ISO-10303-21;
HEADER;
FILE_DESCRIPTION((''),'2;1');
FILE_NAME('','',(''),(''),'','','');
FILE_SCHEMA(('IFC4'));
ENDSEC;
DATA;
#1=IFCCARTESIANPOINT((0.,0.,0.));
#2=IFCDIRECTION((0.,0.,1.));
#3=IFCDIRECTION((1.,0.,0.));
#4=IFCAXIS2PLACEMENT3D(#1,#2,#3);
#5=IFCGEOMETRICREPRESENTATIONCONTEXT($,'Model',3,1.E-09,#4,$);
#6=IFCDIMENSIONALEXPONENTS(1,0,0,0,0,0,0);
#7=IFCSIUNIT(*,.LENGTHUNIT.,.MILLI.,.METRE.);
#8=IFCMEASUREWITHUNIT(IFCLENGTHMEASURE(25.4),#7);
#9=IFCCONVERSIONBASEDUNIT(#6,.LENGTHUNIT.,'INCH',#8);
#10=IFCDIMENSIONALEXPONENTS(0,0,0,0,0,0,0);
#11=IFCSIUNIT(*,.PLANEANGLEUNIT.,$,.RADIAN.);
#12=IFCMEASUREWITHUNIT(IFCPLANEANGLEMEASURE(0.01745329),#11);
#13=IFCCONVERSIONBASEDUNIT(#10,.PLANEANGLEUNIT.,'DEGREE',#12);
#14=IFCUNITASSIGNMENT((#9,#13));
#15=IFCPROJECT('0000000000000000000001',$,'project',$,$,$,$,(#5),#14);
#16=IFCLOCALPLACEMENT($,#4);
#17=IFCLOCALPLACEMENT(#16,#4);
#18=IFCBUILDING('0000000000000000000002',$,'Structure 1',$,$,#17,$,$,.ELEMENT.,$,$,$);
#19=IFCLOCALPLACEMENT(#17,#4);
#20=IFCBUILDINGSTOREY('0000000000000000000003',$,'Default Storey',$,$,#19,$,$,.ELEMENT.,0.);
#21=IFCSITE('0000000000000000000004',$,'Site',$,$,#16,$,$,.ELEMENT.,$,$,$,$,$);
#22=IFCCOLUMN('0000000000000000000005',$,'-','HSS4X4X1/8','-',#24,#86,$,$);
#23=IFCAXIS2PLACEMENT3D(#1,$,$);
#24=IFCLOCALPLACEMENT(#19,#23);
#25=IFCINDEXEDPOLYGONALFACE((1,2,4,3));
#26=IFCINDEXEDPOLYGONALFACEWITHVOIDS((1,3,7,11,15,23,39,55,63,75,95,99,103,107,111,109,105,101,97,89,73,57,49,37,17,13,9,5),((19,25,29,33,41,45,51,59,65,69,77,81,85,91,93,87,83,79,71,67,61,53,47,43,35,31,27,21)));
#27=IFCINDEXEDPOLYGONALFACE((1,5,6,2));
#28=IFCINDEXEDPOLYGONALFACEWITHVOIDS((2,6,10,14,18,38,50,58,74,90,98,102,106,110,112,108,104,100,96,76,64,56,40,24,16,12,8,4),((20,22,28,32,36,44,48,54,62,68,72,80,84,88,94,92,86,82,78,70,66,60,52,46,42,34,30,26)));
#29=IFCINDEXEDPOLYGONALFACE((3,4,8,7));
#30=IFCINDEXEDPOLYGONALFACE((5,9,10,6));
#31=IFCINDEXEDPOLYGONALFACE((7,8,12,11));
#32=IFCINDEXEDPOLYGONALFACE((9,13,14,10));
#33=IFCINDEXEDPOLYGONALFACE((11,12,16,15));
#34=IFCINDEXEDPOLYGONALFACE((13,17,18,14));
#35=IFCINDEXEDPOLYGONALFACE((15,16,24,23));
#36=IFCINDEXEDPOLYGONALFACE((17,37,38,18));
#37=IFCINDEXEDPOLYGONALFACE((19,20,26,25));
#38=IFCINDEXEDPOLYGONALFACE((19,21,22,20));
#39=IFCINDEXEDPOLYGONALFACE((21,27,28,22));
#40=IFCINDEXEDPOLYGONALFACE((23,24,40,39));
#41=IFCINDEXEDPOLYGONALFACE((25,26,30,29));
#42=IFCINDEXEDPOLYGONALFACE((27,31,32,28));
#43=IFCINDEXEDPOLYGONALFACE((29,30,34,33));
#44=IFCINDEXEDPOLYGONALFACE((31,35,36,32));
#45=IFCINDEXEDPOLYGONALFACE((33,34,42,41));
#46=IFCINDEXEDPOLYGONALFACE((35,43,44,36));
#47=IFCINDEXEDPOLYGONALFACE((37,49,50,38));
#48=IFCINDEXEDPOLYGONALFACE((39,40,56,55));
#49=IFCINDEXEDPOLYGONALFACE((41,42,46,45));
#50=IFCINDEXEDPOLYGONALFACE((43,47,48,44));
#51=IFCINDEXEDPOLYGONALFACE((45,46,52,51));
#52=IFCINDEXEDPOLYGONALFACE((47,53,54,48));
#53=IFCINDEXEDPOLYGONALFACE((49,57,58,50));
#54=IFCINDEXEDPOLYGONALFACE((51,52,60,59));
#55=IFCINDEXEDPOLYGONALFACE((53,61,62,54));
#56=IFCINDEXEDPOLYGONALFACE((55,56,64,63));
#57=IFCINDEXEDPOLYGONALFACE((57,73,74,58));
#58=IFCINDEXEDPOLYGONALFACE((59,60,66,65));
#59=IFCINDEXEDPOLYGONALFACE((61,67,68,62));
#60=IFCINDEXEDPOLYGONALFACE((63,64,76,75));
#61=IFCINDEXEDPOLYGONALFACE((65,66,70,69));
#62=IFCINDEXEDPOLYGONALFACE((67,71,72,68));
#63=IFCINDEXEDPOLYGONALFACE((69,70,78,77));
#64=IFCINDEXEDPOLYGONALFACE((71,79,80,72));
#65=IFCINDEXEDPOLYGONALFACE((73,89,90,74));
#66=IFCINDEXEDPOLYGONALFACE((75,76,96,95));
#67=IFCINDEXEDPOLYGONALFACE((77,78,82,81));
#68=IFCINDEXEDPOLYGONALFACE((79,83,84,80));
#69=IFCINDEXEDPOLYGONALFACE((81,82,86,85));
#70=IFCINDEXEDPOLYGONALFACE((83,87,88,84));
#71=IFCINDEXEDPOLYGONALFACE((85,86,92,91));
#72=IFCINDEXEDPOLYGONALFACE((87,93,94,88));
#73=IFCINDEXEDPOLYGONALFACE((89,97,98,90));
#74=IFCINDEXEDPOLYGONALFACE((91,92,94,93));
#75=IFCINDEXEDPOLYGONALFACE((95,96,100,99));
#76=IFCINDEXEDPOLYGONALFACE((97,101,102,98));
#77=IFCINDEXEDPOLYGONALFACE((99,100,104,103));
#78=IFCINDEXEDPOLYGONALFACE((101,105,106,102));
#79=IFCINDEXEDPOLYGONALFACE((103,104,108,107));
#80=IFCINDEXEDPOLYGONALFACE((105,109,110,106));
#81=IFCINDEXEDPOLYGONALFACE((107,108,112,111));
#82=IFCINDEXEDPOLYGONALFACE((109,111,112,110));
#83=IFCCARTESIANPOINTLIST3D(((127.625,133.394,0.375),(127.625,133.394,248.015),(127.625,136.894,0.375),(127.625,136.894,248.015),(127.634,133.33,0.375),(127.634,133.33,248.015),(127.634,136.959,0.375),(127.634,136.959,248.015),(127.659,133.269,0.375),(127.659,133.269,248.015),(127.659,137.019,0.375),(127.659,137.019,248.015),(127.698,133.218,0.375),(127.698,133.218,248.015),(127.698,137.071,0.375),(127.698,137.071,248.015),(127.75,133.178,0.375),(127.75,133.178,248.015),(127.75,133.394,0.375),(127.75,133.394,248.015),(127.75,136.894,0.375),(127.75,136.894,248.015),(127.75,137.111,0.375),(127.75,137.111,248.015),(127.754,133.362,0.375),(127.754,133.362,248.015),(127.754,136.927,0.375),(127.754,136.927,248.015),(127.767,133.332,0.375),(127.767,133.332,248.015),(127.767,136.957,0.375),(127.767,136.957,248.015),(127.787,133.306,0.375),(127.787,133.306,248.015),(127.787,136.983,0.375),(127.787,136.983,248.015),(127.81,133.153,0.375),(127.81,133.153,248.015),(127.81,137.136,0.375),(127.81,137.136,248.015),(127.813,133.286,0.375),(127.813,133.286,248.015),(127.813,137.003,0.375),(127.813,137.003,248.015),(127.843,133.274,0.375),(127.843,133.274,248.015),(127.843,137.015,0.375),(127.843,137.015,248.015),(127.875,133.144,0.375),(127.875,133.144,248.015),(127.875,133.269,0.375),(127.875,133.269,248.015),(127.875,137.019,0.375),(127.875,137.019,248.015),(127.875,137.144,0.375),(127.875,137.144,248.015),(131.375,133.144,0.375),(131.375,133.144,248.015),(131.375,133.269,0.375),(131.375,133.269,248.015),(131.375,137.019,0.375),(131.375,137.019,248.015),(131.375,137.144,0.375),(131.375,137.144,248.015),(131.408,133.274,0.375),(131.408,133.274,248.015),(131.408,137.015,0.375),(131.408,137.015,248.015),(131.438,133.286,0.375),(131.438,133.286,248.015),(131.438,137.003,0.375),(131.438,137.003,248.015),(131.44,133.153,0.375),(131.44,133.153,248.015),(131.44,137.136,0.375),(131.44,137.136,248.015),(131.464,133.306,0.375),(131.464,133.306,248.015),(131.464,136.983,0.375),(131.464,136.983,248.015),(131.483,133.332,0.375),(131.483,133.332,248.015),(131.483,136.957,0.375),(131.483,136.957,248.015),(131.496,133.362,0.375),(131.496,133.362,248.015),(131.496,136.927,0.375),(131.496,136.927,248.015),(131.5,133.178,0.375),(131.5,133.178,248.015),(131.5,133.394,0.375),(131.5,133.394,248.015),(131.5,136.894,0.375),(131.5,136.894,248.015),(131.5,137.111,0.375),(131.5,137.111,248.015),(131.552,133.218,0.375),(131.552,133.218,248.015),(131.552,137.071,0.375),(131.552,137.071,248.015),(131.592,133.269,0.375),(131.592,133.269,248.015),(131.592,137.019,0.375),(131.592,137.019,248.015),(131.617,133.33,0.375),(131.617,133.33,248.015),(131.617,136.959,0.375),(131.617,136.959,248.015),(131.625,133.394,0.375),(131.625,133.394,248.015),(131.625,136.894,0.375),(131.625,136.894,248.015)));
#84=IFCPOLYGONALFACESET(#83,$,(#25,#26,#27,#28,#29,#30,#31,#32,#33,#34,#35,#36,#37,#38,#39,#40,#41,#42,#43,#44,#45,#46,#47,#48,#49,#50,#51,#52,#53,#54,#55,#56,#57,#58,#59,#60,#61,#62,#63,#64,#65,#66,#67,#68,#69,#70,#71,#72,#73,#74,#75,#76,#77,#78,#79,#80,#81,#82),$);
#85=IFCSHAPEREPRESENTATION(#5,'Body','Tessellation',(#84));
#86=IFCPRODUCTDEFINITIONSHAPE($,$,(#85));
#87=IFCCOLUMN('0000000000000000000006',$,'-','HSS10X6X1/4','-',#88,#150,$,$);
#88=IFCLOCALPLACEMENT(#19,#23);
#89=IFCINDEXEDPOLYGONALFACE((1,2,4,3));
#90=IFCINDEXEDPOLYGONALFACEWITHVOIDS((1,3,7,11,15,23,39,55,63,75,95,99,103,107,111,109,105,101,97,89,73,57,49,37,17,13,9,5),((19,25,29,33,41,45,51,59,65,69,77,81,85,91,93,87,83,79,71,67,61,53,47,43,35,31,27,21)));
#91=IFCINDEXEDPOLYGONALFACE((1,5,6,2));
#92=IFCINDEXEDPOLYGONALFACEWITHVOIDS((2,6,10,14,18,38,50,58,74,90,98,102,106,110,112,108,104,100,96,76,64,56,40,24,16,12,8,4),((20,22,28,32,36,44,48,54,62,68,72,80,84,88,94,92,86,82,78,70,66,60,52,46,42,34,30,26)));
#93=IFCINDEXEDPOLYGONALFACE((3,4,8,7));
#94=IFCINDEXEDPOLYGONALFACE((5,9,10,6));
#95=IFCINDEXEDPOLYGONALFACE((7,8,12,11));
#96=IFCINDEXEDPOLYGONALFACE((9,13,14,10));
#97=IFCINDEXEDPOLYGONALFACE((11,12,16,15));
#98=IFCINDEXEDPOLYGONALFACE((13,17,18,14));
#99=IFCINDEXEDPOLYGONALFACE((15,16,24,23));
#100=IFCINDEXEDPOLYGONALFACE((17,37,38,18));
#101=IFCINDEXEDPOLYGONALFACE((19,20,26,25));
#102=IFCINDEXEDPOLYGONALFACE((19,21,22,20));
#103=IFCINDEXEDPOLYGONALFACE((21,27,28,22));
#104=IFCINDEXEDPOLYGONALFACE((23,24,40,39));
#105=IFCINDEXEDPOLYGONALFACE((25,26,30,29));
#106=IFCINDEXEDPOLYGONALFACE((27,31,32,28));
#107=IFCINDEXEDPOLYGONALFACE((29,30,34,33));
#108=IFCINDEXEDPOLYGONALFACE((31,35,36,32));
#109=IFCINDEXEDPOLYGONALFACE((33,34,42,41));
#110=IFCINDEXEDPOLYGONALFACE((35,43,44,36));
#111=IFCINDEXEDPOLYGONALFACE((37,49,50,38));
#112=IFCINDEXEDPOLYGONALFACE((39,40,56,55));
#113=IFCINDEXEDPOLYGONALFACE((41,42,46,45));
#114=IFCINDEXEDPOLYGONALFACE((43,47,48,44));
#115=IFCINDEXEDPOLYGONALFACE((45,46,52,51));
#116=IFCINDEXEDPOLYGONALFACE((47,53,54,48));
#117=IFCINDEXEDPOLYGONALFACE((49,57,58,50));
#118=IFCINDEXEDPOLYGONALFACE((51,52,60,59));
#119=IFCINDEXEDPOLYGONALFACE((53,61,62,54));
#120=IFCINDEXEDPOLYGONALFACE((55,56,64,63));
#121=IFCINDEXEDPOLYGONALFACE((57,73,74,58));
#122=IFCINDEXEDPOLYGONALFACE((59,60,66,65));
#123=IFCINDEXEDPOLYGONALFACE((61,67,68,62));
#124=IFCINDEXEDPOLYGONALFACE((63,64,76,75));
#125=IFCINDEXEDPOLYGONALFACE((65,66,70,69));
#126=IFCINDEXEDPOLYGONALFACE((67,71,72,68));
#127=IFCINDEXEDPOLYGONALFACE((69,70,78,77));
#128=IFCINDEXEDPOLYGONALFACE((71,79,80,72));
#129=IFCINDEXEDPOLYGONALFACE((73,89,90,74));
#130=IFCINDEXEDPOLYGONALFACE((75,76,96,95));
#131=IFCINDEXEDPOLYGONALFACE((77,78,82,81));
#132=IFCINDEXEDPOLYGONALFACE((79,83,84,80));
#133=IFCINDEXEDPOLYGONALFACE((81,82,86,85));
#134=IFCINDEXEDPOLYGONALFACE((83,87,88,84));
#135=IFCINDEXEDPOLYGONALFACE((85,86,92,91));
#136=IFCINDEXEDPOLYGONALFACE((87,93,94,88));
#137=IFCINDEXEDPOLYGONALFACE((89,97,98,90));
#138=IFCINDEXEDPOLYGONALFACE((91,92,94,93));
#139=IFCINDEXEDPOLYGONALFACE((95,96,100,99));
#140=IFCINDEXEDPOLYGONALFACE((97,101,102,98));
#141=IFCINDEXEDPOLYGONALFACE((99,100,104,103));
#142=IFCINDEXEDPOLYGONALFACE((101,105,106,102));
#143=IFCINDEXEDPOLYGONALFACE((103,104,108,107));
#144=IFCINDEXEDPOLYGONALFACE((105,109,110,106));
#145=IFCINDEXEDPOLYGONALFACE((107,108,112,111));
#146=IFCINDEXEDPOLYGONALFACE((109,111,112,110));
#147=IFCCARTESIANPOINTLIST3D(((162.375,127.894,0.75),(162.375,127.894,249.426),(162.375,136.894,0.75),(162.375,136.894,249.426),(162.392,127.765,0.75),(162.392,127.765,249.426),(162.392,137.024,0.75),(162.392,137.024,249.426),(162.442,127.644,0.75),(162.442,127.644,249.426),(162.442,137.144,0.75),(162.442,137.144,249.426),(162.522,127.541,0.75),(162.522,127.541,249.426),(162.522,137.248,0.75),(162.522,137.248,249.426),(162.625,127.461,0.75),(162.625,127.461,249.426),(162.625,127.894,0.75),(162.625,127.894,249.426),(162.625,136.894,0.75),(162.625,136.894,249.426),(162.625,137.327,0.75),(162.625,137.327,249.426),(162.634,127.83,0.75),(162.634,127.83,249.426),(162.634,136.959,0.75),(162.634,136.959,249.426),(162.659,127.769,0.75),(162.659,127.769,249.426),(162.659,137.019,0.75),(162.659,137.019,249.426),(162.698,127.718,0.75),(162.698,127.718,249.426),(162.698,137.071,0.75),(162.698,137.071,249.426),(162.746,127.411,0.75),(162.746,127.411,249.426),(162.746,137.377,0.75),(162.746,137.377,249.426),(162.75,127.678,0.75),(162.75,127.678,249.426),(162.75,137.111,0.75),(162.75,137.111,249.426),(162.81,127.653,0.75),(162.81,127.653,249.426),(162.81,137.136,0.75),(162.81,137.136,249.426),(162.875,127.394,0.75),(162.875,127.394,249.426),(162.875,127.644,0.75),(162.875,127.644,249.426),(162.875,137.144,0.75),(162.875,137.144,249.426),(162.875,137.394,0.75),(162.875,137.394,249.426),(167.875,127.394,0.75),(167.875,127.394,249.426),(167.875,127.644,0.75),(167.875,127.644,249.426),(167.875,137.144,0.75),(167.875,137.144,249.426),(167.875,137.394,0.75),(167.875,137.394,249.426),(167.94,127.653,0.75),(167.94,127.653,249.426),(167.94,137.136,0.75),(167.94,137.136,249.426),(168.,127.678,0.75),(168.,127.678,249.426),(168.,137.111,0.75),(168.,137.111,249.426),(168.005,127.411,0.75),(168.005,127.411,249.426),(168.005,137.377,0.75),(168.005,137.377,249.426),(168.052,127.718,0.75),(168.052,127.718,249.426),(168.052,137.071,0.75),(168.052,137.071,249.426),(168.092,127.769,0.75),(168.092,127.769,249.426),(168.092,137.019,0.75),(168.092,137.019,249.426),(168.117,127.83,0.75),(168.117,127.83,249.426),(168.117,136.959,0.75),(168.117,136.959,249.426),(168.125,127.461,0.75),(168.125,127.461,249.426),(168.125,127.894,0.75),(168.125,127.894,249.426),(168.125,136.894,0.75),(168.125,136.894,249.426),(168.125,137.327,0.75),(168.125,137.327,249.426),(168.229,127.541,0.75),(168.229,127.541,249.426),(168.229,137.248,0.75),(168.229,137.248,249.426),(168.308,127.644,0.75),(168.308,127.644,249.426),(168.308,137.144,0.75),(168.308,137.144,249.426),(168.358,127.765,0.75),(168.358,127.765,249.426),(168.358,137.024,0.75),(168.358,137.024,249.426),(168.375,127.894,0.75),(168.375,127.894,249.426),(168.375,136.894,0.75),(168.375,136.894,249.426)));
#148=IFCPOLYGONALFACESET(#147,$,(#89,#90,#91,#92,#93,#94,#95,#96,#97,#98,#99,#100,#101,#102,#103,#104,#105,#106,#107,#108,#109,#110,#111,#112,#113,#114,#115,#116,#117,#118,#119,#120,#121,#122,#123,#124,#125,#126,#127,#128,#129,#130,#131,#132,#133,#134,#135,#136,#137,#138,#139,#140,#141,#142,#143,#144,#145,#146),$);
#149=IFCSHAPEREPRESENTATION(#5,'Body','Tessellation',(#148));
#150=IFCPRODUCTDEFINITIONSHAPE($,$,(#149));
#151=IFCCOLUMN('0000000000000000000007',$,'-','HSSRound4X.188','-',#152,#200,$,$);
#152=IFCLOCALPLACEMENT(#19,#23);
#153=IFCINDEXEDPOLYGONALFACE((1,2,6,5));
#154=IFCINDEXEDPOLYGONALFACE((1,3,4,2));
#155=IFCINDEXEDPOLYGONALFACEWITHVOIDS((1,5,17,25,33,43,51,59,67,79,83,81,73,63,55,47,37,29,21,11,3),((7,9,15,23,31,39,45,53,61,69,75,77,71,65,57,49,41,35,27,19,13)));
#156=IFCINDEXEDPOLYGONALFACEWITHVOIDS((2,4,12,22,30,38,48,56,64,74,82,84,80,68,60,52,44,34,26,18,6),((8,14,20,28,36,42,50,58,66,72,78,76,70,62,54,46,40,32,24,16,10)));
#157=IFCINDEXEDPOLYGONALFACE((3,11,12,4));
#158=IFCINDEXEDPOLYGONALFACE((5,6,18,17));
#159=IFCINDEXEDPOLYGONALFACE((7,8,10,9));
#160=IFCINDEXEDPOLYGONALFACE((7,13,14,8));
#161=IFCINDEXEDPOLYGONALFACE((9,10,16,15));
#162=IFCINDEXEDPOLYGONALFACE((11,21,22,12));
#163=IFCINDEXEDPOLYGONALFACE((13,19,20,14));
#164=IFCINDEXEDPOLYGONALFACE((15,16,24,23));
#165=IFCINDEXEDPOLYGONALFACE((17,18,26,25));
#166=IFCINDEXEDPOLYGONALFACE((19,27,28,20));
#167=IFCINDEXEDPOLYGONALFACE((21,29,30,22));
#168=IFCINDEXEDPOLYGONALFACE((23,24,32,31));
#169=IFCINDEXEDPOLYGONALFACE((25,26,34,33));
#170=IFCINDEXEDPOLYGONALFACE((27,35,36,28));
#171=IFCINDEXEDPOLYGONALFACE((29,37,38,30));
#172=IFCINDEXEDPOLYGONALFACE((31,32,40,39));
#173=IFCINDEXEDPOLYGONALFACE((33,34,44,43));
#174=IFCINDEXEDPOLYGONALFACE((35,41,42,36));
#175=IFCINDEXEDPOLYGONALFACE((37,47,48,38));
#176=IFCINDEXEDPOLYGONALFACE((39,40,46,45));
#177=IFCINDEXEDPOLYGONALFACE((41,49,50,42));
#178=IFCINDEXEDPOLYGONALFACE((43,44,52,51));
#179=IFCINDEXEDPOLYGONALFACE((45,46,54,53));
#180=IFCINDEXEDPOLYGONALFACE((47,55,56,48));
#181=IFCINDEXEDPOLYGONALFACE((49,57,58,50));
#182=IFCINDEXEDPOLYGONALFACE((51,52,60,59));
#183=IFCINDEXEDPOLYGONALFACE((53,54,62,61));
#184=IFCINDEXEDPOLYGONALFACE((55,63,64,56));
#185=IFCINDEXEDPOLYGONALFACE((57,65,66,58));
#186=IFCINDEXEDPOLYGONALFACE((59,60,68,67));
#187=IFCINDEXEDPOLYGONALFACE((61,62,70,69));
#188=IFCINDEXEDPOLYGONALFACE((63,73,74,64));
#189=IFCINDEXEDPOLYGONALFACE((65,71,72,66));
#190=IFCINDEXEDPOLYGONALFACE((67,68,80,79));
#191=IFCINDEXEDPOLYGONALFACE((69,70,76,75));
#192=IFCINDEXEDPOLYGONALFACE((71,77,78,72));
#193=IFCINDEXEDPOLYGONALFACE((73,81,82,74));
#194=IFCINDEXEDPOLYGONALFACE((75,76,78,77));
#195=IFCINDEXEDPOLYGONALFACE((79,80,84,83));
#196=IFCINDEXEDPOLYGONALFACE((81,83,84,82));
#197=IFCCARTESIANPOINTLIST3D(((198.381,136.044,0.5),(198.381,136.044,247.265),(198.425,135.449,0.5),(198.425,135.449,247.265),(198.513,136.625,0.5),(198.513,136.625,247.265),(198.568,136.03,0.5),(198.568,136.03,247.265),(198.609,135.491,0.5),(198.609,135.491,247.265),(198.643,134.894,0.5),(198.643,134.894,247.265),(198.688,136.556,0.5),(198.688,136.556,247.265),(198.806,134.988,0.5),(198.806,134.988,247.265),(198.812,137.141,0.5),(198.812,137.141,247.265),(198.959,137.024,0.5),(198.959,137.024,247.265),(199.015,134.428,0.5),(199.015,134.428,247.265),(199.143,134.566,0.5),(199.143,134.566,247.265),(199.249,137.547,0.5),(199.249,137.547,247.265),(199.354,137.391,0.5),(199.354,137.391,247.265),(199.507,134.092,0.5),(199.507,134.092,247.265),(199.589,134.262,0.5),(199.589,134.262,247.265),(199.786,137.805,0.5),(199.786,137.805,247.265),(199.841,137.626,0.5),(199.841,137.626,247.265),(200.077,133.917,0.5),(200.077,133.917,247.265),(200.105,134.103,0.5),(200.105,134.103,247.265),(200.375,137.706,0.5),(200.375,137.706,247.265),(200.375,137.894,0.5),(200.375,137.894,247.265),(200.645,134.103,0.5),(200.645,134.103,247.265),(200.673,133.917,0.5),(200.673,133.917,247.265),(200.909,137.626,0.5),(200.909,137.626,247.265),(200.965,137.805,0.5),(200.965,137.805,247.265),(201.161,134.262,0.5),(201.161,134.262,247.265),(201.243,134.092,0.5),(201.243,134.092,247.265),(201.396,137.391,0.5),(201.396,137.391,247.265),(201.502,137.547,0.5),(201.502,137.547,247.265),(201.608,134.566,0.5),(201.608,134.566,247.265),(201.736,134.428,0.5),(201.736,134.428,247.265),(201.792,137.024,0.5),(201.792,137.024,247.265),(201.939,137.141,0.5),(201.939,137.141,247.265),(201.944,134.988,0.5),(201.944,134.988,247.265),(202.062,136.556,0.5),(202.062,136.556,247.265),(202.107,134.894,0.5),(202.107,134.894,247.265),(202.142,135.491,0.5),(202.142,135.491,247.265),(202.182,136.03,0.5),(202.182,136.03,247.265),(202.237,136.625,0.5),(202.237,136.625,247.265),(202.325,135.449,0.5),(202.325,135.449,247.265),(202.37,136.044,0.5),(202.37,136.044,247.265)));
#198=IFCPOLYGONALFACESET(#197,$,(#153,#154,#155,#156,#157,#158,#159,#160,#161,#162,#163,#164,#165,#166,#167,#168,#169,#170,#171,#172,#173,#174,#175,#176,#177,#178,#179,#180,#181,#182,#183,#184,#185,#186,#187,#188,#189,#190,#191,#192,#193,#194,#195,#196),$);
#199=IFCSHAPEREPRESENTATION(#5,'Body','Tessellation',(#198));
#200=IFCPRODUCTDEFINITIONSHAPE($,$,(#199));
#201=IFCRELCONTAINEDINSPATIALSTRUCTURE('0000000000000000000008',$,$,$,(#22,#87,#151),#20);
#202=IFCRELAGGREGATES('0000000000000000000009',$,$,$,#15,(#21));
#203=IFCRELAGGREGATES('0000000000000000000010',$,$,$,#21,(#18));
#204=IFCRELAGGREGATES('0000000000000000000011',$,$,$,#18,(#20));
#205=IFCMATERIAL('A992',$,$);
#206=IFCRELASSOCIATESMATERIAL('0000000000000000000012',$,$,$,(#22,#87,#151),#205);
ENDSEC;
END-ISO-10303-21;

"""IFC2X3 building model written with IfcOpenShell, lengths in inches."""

from ifc_helpers import new_model, entity, si_unit, converted_unit, frame, origin, origin_with_axes, origin_2d, place, context, project, spatial, hollow_rectangle, hollow_circle, extrude, clip, halfspace, material, element, save


model = new_model("IFC2X3")

# Units and contexts
model_context = context("Model", 3, precision=1e-09, world=origin_with_axes())
ifc_project = project(units=[converted_unit("LENGTHUNIT", "INCH", entity("IfcLengthMeasure", 25.4), si_unit("LENGTHUNIT", "METRE", prefix="MILLI"), dimensions=[1, 0, 0, 0, 0, 0, 0]), converted_unit("PLANEANGLEUNIT", "DEGREE", entity("IfcPlaneAngleMeasure", 0.01745329), si_unit("PLANEANGLEUNIT", "RADIAN"), dimensions=[0, 0, 0, 0, 0, 0, 0])], contexts=[model_context])

# Site, building, storey
site_placement = place(None, origin_with_axes())
site = spatial("IfcSite", under=ifc_project, at=site_placement, Name="Site", CompositionType="ELEMENT")
building_placement = place(site_placement, origin_with_axes())
building = spatial("IfcBuilding", under=site, at=building_placement, Name="Structure 1", CompositionType="ELEMENT")
storey_placement = place(building_placement, origin_with_axes())
storey = spatial("IfcBuildingStorey", under=building, at=storey_placement, Name="Default Storey", CompositionType="ELEMENT", Elevation=0.0)

# Columns
ifc_material_1 = material(Name="A992")
column_1_placement = place(None, frame((129.625, 135.144, -4.828), z_axis=(0.0, 0.0, -1.0), x_axis=(0.0, 1.0, 0.0)))
element("IfcColumn", 1, at=column_1_placement, inside=storey, material=ifc_material_1, Name="-", Description="HSS4X4X1/8", ObjectType="-", context=model_context, shape_type="Clipping", body=[
    clip(extrude(hollow_rectangle(XDim=4.0, YDim=4.0, WallThickness=0.125, InnerFilletRadius=0.125, OuterFilletRadius=0.25, at=origin_2d()), origin(), (0.0, 0.0, -1.0), 252.844), halfspace(frame((-135.144, -129.625, -5.203), z_axis=(0.0, 0.0, -1.0), x_axis=(0.0, 1.0, 0.0)), True)),
])
column_2_placement = place(None, frame((165.375, 132.394, -10.831), z_axis=(0.0, 0.0, -1.0), x_axis=(1.0, 0.0, 0.0)))
element("IfcColumn", 2, at=column_2_placement, inside=storey, material=ifc_material_1, Name="-", Description="HSS10X6X1/4", ObjectType="-", context=model_context, shape_type="Clipping", body=[
    clip(extrude(hollow_rectangle(XDim=6.0, YDim=10.0, WallThickness=0.25, InnerFilletRadius=0.25, OuterFilletRadius=0.5, at=origin_2d()), origin(), (0.0, 0.0, -1.0), 260.257), halfspace(frame((-165.375, 132.394, -11.581), z_axis=(0.0, 0.0, -1.0), x_axis=(1.0, 0.0, 0.0)), True)),
])
column_3_placement = place(None, frame((200.375, 135.894, -2.828), z_axis=(0.0, 0.0, -1.0), x_axis=(0.0, 1.0, 0.0)))
element("IfcColumn", 3, at=column_3_placement, inside=storey, material=ifc_material_1, Name="-", Description="HSSRound4X.188", ObjectType="-", context=model_context, shape_type="Clipping", body=[
    clip(extrude(hollow_circle(Radius=2.0, WallThickness=0.188, at=origin_2d()), origin(), (0.0, 0.0, -1.0), 250.094), halfspace(frame((-135.894, -200.375, -3.328), z_axis=(0.0, 0.0, -1.0), x_axis=(0.0, 1.0, 0.0)), True)),
])

save(model, "model.ifc")
